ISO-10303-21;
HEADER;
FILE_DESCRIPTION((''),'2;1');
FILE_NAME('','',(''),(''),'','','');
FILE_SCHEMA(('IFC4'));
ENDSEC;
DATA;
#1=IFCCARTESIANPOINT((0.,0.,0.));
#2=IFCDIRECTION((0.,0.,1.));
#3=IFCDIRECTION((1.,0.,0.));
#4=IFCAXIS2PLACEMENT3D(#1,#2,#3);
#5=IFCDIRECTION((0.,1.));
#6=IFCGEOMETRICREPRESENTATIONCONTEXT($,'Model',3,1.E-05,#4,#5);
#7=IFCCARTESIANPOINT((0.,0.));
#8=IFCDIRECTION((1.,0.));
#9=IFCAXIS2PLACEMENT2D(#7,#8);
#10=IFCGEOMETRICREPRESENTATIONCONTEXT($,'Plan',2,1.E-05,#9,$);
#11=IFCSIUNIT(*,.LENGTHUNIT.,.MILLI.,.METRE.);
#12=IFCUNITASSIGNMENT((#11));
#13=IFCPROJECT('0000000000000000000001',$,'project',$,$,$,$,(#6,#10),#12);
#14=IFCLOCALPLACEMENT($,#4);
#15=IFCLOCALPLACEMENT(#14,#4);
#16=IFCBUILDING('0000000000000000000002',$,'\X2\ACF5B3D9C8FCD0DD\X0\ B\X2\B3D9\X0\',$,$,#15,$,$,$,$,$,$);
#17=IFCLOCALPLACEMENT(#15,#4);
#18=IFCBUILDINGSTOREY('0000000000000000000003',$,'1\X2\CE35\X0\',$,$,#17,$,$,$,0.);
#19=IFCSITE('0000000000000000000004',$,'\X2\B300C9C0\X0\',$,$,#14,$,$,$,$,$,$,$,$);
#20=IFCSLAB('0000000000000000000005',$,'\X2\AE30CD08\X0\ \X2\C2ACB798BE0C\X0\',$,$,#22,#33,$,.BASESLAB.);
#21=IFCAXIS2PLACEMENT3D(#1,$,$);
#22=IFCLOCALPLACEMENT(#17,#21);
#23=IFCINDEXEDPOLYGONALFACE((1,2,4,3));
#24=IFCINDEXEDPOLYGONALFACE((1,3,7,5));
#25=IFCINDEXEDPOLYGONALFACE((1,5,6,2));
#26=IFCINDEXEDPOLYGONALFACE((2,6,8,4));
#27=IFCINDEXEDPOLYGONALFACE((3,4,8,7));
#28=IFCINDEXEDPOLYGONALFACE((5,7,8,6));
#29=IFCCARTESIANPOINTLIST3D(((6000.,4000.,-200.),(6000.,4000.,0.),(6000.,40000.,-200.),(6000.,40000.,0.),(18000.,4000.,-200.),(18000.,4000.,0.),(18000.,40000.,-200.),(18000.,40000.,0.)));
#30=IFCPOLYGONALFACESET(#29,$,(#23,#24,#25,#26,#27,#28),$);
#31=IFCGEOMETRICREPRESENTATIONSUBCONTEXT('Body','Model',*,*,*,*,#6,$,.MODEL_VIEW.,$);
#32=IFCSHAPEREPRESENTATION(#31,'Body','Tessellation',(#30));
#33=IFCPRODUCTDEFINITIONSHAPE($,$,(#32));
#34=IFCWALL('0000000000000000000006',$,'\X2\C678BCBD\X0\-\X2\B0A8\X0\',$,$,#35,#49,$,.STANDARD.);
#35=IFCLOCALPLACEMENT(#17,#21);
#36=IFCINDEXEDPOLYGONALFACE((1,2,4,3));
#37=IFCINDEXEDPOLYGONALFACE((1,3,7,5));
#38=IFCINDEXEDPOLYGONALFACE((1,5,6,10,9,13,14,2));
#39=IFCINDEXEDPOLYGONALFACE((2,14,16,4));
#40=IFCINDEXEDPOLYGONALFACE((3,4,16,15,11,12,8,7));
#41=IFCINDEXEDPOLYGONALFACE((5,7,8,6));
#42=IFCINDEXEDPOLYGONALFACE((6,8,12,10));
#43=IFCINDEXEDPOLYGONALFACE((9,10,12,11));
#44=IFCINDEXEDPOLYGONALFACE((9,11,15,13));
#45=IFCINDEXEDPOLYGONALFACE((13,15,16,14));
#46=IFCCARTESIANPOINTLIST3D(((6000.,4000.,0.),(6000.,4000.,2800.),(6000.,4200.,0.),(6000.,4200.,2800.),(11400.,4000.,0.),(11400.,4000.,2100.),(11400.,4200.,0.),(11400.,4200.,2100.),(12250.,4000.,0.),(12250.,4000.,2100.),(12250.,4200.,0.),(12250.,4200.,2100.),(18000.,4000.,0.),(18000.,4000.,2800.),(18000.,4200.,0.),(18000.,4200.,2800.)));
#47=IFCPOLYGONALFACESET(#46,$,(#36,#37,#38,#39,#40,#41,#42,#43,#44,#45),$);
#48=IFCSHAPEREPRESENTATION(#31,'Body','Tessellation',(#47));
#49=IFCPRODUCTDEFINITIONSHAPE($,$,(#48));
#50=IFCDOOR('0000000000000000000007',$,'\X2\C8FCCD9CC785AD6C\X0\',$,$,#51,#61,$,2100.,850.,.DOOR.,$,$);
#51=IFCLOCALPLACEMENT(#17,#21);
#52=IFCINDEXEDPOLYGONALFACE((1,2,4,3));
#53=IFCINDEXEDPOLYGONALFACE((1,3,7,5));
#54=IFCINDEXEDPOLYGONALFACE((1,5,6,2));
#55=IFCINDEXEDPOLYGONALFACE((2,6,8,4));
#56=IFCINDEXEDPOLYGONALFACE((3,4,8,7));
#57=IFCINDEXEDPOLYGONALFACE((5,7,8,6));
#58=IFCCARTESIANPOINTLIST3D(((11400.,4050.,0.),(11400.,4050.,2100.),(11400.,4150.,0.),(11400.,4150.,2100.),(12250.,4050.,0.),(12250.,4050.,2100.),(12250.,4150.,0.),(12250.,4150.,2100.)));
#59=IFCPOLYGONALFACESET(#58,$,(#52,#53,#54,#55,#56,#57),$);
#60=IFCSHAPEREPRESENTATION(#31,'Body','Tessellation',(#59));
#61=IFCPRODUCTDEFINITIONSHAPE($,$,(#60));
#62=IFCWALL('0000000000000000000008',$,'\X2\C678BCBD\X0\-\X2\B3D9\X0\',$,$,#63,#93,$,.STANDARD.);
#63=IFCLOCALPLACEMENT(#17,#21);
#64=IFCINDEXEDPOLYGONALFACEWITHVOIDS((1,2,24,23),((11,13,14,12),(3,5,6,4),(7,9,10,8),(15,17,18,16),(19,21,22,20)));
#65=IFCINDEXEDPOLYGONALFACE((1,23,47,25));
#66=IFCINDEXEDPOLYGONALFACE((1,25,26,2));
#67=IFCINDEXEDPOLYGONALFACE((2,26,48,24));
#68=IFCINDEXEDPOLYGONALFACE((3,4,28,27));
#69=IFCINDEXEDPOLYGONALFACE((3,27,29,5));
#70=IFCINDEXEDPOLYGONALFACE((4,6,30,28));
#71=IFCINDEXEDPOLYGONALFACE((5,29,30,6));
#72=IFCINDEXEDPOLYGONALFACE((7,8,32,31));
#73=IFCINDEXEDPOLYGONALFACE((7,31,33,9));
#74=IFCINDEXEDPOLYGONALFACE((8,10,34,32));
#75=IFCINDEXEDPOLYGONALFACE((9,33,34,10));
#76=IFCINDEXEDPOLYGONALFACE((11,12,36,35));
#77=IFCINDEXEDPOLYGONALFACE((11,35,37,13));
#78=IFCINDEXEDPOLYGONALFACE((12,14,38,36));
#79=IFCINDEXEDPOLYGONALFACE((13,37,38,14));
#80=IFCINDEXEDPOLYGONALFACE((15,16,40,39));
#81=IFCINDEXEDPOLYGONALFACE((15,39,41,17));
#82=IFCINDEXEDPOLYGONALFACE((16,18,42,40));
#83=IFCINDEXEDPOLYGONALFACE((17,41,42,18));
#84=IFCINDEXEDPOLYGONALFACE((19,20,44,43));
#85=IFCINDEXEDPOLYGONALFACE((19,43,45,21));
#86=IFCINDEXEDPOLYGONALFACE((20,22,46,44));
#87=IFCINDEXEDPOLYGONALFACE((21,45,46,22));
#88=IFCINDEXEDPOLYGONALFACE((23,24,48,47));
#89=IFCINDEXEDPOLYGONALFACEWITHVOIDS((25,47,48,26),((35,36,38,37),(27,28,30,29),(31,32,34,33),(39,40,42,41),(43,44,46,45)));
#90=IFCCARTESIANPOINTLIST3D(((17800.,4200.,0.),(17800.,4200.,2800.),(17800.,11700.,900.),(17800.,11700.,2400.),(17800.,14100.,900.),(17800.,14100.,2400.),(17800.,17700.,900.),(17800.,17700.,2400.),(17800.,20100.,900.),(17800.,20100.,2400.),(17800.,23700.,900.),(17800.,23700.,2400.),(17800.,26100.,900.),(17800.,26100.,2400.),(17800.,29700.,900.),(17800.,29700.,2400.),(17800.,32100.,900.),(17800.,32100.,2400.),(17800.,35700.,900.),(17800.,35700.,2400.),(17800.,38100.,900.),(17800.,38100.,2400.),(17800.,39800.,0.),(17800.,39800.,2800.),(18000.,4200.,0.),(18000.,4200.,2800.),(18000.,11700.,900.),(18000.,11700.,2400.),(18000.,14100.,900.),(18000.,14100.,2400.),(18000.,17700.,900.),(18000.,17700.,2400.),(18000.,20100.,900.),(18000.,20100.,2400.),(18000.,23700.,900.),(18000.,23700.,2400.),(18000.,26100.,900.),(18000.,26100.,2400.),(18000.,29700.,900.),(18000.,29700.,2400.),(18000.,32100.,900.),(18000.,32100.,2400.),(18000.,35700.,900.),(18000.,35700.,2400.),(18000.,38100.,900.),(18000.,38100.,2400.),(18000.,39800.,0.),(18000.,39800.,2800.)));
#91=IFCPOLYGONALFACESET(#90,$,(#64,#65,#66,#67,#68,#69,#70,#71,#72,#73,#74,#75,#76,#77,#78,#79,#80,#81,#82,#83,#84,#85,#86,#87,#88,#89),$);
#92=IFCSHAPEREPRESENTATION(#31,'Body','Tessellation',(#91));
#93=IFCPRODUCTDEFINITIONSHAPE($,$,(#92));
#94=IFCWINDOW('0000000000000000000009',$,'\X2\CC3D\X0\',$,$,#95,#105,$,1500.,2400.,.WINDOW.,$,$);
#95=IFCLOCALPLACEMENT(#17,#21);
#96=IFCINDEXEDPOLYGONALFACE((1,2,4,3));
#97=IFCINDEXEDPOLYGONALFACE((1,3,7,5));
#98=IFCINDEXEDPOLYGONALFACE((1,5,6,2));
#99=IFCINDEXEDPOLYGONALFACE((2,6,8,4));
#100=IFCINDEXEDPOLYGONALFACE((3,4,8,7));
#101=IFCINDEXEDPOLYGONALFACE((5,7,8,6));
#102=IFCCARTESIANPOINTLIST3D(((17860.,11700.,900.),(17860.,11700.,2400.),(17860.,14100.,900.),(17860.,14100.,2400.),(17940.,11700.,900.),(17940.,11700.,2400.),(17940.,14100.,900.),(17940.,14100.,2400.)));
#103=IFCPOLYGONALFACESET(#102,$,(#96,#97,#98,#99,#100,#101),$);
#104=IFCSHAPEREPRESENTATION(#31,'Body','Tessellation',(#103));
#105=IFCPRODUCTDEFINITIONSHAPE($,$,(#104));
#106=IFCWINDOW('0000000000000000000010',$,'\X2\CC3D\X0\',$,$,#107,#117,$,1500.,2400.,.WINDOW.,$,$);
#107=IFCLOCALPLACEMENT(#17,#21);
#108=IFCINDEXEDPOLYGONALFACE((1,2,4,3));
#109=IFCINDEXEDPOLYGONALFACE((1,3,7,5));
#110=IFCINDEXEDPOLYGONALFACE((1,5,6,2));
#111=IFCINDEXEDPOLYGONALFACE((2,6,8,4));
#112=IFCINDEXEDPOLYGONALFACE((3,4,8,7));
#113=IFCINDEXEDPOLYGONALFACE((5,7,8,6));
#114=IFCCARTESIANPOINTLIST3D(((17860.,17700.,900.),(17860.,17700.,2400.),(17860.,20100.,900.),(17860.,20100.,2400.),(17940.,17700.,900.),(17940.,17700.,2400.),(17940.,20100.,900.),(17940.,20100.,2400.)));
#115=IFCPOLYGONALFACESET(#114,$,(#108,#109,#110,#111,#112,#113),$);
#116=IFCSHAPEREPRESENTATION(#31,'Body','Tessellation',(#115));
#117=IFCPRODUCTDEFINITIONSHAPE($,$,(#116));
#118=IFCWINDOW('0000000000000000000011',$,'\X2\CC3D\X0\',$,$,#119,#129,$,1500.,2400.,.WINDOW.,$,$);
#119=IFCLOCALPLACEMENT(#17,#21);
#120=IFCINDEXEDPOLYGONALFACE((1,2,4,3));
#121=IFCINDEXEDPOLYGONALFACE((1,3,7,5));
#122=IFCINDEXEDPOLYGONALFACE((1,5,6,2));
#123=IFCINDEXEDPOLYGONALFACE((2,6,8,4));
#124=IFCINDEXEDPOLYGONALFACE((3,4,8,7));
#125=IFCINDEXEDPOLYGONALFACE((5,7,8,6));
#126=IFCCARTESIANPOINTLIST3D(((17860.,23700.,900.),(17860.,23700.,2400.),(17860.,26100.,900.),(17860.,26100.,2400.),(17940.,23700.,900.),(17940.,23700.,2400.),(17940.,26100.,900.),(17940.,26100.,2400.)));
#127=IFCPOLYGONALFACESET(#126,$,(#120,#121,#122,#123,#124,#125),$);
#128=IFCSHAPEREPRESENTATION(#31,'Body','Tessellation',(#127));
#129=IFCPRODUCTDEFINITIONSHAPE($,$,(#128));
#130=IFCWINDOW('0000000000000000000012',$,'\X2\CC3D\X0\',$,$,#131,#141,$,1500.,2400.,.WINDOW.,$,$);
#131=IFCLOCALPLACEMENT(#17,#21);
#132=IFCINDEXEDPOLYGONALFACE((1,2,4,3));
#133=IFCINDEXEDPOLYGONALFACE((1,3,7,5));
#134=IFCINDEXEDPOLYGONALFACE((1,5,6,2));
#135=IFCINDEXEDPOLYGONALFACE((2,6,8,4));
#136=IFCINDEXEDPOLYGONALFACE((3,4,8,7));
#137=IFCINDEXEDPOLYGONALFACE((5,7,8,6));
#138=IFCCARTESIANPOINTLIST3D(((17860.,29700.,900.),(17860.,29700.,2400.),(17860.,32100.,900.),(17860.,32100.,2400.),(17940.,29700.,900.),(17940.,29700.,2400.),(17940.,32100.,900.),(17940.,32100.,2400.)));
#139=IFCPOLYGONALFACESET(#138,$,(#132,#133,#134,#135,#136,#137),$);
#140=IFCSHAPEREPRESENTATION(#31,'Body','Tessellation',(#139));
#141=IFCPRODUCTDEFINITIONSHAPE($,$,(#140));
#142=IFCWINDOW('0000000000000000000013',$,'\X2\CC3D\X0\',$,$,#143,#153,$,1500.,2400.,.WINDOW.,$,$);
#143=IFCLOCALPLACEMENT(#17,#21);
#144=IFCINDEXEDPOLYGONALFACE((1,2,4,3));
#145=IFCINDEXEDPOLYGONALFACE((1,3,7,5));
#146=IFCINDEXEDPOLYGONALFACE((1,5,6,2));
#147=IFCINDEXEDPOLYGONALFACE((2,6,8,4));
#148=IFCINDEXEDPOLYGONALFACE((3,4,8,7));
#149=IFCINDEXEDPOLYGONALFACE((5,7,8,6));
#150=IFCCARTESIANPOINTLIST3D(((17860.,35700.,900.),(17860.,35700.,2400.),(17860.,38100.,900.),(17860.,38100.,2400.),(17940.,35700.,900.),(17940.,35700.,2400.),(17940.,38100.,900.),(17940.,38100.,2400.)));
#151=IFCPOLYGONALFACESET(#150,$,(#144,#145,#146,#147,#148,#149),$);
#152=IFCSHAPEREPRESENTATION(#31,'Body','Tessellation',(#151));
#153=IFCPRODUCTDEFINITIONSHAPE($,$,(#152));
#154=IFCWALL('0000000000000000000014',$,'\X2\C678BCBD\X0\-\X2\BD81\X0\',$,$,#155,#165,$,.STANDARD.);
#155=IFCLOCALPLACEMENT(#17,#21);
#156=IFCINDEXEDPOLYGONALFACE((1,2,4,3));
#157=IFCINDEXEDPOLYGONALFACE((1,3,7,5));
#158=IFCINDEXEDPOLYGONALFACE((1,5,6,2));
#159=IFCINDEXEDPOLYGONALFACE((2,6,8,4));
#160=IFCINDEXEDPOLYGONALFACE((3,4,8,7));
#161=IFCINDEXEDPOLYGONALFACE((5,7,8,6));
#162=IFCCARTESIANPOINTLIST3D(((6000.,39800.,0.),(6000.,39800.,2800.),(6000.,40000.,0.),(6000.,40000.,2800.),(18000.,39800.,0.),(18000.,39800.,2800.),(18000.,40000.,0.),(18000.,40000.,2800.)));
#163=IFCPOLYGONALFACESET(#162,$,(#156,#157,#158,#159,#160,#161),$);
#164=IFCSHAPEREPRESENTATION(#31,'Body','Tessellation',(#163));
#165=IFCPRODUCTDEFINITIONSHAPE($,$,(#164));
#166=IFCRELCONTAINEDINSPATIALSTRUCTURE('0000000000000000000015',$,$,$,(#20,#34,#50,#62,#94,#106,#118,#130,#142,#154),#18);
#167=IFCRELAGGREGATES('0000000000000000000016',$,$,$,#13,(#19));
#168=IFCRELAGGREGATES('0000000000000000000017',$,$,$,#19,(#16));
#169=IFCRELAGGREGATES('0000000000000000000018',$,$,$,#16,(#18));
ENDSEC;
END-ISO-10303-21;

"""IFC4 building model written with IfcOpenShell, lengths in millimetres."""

from ifc_helpers import new_model, si_unit, direction, frame, origin_with_axes, origin_2d_with_axis, place, context, subcontext, project, spatial, polyline, outline, extrude, element, fill, save


model = new_model("IFC4")

# Units and contexts
model_context = context("Model", 3, precision=1e-05, world=origin_with_axes(), true_north=direction((0.0, 1.0)))
plan_context = context("Plan", 2, precision=1e-05, world=origin_2d_with_axis())
body_context = subcontext(model_context, "Body", "Model", "MODEL_VIEW")
ifc_project = project(units=[si_unit("LENGTHUNIT", "METRE", prefix="MILLI")], contexts=[model_context, plan_context])

# Site, building, storey
site_placement = place(None, origin_with_axes())
site = spatial("IfcSite", under=ifc_project, at=site_placement, Name="대지")
building_placement = place(site_placement, origin_with_axes())
building = spatial("IfcBuilding", under=site, at=building_placement, Name="공동주택 B동")
storey_placement = place(building_placement, origin_with_axes())
storey = spatial("IfcBuildingStorey", under=building, at=storey_placement, Name="1층", Elevation=0.0)

# Slab
slab_placement = place(storey_placement, origin_with_axes())
element("IfcSlab", 1, at=slab_placement, inside=storey, Name="기초 슬래브", PredefinedType="BASESLAB", context=body_context, shape_type="SweptSolid", body=[
    extrude(outline(polyline([(6000.0, 4000.0), (18000.0, 4000.0), (18000.0, 40000.0), (6000.0, 40000.0), (6000.0, 4000.0)])), frame((0.0, 0.0, -200.0), z_axis=(0.0, 0.0, 1.0), x_axis=(1.0, 0.0, 0.0)), (0.0, 0.0, 1.0), 200.0),
])

# Wall, opening, door
wall_1_placement = place(storey_placement, origin_with_axes())
wall_1 = element("IfcWall", 2, at=wall_1_placement, inside=storey, Name="외벽-남", PredefinedType="STANDARD", context=body_context, shape_type="SweptSolid", body=[
    extrude(outline(polyline([(6000.0, 4200.0), (18000.0, 4200.0), (18000.0, 4000.0), (6000.0, 4000.0), (6000.0, 4200.0)])), origin_with_axes(), (0.0, 0.0, 1.0), 2800.0),
])
opening_1_placement = place(storey_placement, origin_with_axes())
opening_1 = element("IfcOpeningElement", 3, at=opening_1_placement, cuts=wall_1, PredefinedType="OPENING", context=body_context, shape_type="SweptSolid", body=[
    extrude(outline(polyline([(11400.0, 3950.0), (12250.0, 3950.0), (12250.0, 4250.0), (11400.0, 4250.0), (11400.0, 3950.0)])), origin_with_axes(), (0.0, 0.0, 1.0), 2100.0),
])
door_placement = place(storey_placement, origin_with_axes())
door = element("IfcDoor", 4, at=door_placement, inside=storey, Name="주출입구", OverallHeight=2100.0, OverallWidth=850.0, PredefinedType="DOOR", context=body_context, shape_type="SweptSolid", body=[
    extrude(outline(polyline([(11400.0, 4050.0), (12250.0, 4050.0), (12250.0, 4150.0), (11400.0, 4150.0), (11400.0, 4050.0)])), origin_with_axes(), (0.0, 0.0, 1.0), 2100.0),
])
fill(opening_1, door)

# Wall, openings, windows
wall_2_placement = place(storey_placement, origin_with_axes())
wall_2 = element("IfcWall", 5, at=wall_2_placement, inside=storey, Name="외벽-동", PredefinedType="STANDARD", context=body_context, shape_type="SweptSolid", body=[
    extrude(outline(polyline([(17800.0, 4200.0), (17800.0, 39800.0), (18000.0, 39800.0), (18000.0, 4200.0), (17800.0, 4200.0)])), origin_with_axes(), (0.0, 0.0, 1.0), 2800.0),
])
opening_2_placement = place(storey_placement, origin_with_axes())
opening_2 = element("IfcOpeningElement", 6, at=opening_2_placement, cuts=wall_2, PredefinedType="OPENING", context=body_context, shape_type="SweptSolid", body=[
    extrude(outline(polyline([(18050.0, 11700.0), (18050.0, 14100.0), (17750.0, 14100.0), (17750.0, 11700.0), (18050.0, 11700.0)])), frame((0.0, 0.0, 900.0), z_axis=(0.0, 0.0, 1.0), x_axis=(1.0, 0.0, 0.0)), (0.0, 0.0, 1.0), 1500.0),
])
opening_3_placement = place(storey_placement, origin_with_axes())
opening_3 = element("IfcOpeningElement", 7, at=opening_3_placement, cuts=wall_2, PredefinedType="OPENING", context=body_context, shape_type="SweptSolid", body=[
    extrude(outline(polyline([(18050.0, 17700.0), (18050.0, 20100.0), (17750.0, 20100.0), (17750.0, 17700.0), (18050.0, 17700.0)])), frame((0.0, 0.0, 900.0), z_axis=(0.0, 0.0, 1.0), x_axis=(1.0, 0.0, 0.0)), (0.0, 0.0, 1.0), 1500.0),
])
opening_4_placement = place(storey_placement, origin_with_axes())
opening_4 = element("IfcOpeningElement", 8, at=opening_4_placement, cuts=wall_2, PredefinedType="OPENING", context=body_context, shape_type="SweptSolid", body=[
    extrude(outline(polyline([(18050.0, 23700.0), (18050.0, 26100.0), (17750.0, 26100.0), (17750.0, 23700.0), (18050.0, 23700.0)])), frame((0.0, 0.0, 900.0), z_axis=(0.0, 0.0, 1.0), x_axis=(1.0, 0.0, 0.0)), (0.0, 0.0, 1.0), 1500.0),
])
opening_5_placement = place(storey_placement, origin_with_axes())
opening_5 = element("IfcOpeningElement", 9, at=opening_5_placement, cuts=wall_2, PredefinedType="OPENING", context=body_context, shape_type="SweptSolid", body=[
    extrude(outline(polyline([(18050.0, 29700.0), (18050.0, 32100.0), (17750.0, 32100.0), (17750.0, 29700.0), (18050.0, 29700.0)])), frame((0.0, 0.0, 900.0), z_axis=(0.0, 0.0, 1.0), x_axis=(1.0, 0.0, 0.0)), (0.0, 0.0, 1.0), 1500.0),
])
opening_6_placement = place(storey_placement, origin_with_axes())
opening_6 = element("IfcOpeningElement", 10, at=opening_6_placement, cuts=wall_2, PredefinedType="OPENING", context=body_context, shape_type="SweptSolid", body=[
    extrude(outline(polyline([(18050.0, 35700.0), (18050.0, 38100.0), (17750.0, 38100.0), (17750.0, 35700.0), (18050.0, 35700.0)])), frame((0.0, 0.0, 900.0), z_axis=(0.0, 0.0, 1.0), x_axis=(1.0, 0.0, 0.0)), (0.0, 0.0, 1.0), 1500.0),
])
window_1_placement = place(storey_placement, origin_with_axes())
window_1 = element("IfcWindow", 11, at=window_1_placement, inside=storey, Name="창", OverallHeight=1500.0, OverallWidth=2400.0, PredefinedType="WINDOW", context=body_context, shape_type="SweptSolid", body=[
    extrude(outline(polyline([(17940.0, 11700.0), (17940.0, 14100.0), (17860.0, 14100.0), (17860.0, 11700.0), (17940.0, 11700.0)])), frame((0.0, 0.0, 900.0), z_axis=(0.0, 0.0, 1.0), x_axis=(1.0, 0.0, 0.0)), (0.0, 0.0, 1.0), 1500.0),
])
fill(opening_2, window_1)
window_2_placement = place(storey_placement, origin_with_axes())
window_2 = element("IfcWindow", 12, at=window_2_placement, inside=storey, Name="창", OverallHeight=1500.0, OverallWidth=2400.0, PredefinedType="WINDOW", context=body_context, shape_type="SweptSolid", body=[
    extrude(outline(polyline([(17940.0, 17700.0), (17940.0, 20100.0), (17860.0, 20100.0), (17860.0, 17700.0), (17940.0, 17700.0)])), frame((0.0, 0.0, 900.0), z_axis=(0.0, 0.0, 1.0), x_axis=(1.0, 0.0, 0.0)), (0.0, 0.0, 1.0), 1500.0),
])
fill(opening_3, window_2)
window_3_placement = place(storey_placement, origin_with_axes())
window_3 = element("IfcWindow", 13, at=window_3_placement, inside=storey, Name="창", OverallHeight=1500.0, OverallWidth=2400.0, PredefinedType="WINDOW", context=body_context, shape_type="SweptSolid", body=[
    extrude(outline(polyline([(17940.0, 23700.0), (17940.0, 26100.0), (17860.0, 26100.0), (17860.0, 23700.0), (17940.0, 23700.0)])), frame((0.0, 0.0, 900.0), z_axis=(0.0, 0.0, 1.0), x_axis=(1.0, 0.0, 0.0)), (0.0, 0.0, 1.0), 1500.0),
])
fill(opening_4, window_3)
window_4_placement = place(storey_placement, origin_with_axes())
window_4 = element("IfcWindow", 14, at=window_4_placement, inside=storey, Name="창", OverallHeight=1500.0, OverallWidth=2400.0, PredefinedType="WINDOW", context=body_context, shape_type="SweptSolid", body=[
    extrude(outline(polyline([(17940.0, 29700.0), (17940.0, 32100.0), (17860.0, 32100.0), (17860.0, 29700.0), (17940.0, 29700.0)])), frame((0.0, 0.0, 900.0), z_axis=(0.0, 0.0, 1.0), x_axis=(1.0, 0.0, 0.0)), (0.0, 0.0, 1.0), 1500.0),
])
fill(opening_5, window_4)
window_5_placement = place(storey_placement, origin_with_axes())
window_5 = element("IfcWindow", 15, at=window_5_placement, inside=storey, Name="창", OverallHeight=1500.0, OverallWidth=2400.0, PredefinedType="WINDOW", context=body_context, shape_type="SweptSolid", body=[
    extrude(outline(polyline([(17940.0, 35700.0), (17940.0, 38100.0), (17860.0, 38100.0), (17860.0, 35700.0), (17940.0, 35700.0)])), frame((0.0, 0.0, 900.0), z_axis=(0.0, 0.0, 1.0), x_axis=(1.0, 0.0, 0.0)), (0.0, 0.0, 1.0), 1500.0),
])
fill(opening_6, window_5)

# Wall
wall_3_placement = place(storey_placement, origin_with_axes())
element("IfcWall", 16, at=wall_3_placement, inside=storey, Name="외벽-북", PredefinedType="STANDARD", context=body_context, shape_type="SweptSolid", body=[
    extrude(outline(polyline([(18000.0, 39800.0), (6000.0, 39800.0), (6000.0, 40000.0), (18000.0, 40000.0), (18000.0, 39800.0)])), origin_with_axes(), (0.0, 0.0, 1.0), 2800.0),
])

save(model, "model.ifc")
